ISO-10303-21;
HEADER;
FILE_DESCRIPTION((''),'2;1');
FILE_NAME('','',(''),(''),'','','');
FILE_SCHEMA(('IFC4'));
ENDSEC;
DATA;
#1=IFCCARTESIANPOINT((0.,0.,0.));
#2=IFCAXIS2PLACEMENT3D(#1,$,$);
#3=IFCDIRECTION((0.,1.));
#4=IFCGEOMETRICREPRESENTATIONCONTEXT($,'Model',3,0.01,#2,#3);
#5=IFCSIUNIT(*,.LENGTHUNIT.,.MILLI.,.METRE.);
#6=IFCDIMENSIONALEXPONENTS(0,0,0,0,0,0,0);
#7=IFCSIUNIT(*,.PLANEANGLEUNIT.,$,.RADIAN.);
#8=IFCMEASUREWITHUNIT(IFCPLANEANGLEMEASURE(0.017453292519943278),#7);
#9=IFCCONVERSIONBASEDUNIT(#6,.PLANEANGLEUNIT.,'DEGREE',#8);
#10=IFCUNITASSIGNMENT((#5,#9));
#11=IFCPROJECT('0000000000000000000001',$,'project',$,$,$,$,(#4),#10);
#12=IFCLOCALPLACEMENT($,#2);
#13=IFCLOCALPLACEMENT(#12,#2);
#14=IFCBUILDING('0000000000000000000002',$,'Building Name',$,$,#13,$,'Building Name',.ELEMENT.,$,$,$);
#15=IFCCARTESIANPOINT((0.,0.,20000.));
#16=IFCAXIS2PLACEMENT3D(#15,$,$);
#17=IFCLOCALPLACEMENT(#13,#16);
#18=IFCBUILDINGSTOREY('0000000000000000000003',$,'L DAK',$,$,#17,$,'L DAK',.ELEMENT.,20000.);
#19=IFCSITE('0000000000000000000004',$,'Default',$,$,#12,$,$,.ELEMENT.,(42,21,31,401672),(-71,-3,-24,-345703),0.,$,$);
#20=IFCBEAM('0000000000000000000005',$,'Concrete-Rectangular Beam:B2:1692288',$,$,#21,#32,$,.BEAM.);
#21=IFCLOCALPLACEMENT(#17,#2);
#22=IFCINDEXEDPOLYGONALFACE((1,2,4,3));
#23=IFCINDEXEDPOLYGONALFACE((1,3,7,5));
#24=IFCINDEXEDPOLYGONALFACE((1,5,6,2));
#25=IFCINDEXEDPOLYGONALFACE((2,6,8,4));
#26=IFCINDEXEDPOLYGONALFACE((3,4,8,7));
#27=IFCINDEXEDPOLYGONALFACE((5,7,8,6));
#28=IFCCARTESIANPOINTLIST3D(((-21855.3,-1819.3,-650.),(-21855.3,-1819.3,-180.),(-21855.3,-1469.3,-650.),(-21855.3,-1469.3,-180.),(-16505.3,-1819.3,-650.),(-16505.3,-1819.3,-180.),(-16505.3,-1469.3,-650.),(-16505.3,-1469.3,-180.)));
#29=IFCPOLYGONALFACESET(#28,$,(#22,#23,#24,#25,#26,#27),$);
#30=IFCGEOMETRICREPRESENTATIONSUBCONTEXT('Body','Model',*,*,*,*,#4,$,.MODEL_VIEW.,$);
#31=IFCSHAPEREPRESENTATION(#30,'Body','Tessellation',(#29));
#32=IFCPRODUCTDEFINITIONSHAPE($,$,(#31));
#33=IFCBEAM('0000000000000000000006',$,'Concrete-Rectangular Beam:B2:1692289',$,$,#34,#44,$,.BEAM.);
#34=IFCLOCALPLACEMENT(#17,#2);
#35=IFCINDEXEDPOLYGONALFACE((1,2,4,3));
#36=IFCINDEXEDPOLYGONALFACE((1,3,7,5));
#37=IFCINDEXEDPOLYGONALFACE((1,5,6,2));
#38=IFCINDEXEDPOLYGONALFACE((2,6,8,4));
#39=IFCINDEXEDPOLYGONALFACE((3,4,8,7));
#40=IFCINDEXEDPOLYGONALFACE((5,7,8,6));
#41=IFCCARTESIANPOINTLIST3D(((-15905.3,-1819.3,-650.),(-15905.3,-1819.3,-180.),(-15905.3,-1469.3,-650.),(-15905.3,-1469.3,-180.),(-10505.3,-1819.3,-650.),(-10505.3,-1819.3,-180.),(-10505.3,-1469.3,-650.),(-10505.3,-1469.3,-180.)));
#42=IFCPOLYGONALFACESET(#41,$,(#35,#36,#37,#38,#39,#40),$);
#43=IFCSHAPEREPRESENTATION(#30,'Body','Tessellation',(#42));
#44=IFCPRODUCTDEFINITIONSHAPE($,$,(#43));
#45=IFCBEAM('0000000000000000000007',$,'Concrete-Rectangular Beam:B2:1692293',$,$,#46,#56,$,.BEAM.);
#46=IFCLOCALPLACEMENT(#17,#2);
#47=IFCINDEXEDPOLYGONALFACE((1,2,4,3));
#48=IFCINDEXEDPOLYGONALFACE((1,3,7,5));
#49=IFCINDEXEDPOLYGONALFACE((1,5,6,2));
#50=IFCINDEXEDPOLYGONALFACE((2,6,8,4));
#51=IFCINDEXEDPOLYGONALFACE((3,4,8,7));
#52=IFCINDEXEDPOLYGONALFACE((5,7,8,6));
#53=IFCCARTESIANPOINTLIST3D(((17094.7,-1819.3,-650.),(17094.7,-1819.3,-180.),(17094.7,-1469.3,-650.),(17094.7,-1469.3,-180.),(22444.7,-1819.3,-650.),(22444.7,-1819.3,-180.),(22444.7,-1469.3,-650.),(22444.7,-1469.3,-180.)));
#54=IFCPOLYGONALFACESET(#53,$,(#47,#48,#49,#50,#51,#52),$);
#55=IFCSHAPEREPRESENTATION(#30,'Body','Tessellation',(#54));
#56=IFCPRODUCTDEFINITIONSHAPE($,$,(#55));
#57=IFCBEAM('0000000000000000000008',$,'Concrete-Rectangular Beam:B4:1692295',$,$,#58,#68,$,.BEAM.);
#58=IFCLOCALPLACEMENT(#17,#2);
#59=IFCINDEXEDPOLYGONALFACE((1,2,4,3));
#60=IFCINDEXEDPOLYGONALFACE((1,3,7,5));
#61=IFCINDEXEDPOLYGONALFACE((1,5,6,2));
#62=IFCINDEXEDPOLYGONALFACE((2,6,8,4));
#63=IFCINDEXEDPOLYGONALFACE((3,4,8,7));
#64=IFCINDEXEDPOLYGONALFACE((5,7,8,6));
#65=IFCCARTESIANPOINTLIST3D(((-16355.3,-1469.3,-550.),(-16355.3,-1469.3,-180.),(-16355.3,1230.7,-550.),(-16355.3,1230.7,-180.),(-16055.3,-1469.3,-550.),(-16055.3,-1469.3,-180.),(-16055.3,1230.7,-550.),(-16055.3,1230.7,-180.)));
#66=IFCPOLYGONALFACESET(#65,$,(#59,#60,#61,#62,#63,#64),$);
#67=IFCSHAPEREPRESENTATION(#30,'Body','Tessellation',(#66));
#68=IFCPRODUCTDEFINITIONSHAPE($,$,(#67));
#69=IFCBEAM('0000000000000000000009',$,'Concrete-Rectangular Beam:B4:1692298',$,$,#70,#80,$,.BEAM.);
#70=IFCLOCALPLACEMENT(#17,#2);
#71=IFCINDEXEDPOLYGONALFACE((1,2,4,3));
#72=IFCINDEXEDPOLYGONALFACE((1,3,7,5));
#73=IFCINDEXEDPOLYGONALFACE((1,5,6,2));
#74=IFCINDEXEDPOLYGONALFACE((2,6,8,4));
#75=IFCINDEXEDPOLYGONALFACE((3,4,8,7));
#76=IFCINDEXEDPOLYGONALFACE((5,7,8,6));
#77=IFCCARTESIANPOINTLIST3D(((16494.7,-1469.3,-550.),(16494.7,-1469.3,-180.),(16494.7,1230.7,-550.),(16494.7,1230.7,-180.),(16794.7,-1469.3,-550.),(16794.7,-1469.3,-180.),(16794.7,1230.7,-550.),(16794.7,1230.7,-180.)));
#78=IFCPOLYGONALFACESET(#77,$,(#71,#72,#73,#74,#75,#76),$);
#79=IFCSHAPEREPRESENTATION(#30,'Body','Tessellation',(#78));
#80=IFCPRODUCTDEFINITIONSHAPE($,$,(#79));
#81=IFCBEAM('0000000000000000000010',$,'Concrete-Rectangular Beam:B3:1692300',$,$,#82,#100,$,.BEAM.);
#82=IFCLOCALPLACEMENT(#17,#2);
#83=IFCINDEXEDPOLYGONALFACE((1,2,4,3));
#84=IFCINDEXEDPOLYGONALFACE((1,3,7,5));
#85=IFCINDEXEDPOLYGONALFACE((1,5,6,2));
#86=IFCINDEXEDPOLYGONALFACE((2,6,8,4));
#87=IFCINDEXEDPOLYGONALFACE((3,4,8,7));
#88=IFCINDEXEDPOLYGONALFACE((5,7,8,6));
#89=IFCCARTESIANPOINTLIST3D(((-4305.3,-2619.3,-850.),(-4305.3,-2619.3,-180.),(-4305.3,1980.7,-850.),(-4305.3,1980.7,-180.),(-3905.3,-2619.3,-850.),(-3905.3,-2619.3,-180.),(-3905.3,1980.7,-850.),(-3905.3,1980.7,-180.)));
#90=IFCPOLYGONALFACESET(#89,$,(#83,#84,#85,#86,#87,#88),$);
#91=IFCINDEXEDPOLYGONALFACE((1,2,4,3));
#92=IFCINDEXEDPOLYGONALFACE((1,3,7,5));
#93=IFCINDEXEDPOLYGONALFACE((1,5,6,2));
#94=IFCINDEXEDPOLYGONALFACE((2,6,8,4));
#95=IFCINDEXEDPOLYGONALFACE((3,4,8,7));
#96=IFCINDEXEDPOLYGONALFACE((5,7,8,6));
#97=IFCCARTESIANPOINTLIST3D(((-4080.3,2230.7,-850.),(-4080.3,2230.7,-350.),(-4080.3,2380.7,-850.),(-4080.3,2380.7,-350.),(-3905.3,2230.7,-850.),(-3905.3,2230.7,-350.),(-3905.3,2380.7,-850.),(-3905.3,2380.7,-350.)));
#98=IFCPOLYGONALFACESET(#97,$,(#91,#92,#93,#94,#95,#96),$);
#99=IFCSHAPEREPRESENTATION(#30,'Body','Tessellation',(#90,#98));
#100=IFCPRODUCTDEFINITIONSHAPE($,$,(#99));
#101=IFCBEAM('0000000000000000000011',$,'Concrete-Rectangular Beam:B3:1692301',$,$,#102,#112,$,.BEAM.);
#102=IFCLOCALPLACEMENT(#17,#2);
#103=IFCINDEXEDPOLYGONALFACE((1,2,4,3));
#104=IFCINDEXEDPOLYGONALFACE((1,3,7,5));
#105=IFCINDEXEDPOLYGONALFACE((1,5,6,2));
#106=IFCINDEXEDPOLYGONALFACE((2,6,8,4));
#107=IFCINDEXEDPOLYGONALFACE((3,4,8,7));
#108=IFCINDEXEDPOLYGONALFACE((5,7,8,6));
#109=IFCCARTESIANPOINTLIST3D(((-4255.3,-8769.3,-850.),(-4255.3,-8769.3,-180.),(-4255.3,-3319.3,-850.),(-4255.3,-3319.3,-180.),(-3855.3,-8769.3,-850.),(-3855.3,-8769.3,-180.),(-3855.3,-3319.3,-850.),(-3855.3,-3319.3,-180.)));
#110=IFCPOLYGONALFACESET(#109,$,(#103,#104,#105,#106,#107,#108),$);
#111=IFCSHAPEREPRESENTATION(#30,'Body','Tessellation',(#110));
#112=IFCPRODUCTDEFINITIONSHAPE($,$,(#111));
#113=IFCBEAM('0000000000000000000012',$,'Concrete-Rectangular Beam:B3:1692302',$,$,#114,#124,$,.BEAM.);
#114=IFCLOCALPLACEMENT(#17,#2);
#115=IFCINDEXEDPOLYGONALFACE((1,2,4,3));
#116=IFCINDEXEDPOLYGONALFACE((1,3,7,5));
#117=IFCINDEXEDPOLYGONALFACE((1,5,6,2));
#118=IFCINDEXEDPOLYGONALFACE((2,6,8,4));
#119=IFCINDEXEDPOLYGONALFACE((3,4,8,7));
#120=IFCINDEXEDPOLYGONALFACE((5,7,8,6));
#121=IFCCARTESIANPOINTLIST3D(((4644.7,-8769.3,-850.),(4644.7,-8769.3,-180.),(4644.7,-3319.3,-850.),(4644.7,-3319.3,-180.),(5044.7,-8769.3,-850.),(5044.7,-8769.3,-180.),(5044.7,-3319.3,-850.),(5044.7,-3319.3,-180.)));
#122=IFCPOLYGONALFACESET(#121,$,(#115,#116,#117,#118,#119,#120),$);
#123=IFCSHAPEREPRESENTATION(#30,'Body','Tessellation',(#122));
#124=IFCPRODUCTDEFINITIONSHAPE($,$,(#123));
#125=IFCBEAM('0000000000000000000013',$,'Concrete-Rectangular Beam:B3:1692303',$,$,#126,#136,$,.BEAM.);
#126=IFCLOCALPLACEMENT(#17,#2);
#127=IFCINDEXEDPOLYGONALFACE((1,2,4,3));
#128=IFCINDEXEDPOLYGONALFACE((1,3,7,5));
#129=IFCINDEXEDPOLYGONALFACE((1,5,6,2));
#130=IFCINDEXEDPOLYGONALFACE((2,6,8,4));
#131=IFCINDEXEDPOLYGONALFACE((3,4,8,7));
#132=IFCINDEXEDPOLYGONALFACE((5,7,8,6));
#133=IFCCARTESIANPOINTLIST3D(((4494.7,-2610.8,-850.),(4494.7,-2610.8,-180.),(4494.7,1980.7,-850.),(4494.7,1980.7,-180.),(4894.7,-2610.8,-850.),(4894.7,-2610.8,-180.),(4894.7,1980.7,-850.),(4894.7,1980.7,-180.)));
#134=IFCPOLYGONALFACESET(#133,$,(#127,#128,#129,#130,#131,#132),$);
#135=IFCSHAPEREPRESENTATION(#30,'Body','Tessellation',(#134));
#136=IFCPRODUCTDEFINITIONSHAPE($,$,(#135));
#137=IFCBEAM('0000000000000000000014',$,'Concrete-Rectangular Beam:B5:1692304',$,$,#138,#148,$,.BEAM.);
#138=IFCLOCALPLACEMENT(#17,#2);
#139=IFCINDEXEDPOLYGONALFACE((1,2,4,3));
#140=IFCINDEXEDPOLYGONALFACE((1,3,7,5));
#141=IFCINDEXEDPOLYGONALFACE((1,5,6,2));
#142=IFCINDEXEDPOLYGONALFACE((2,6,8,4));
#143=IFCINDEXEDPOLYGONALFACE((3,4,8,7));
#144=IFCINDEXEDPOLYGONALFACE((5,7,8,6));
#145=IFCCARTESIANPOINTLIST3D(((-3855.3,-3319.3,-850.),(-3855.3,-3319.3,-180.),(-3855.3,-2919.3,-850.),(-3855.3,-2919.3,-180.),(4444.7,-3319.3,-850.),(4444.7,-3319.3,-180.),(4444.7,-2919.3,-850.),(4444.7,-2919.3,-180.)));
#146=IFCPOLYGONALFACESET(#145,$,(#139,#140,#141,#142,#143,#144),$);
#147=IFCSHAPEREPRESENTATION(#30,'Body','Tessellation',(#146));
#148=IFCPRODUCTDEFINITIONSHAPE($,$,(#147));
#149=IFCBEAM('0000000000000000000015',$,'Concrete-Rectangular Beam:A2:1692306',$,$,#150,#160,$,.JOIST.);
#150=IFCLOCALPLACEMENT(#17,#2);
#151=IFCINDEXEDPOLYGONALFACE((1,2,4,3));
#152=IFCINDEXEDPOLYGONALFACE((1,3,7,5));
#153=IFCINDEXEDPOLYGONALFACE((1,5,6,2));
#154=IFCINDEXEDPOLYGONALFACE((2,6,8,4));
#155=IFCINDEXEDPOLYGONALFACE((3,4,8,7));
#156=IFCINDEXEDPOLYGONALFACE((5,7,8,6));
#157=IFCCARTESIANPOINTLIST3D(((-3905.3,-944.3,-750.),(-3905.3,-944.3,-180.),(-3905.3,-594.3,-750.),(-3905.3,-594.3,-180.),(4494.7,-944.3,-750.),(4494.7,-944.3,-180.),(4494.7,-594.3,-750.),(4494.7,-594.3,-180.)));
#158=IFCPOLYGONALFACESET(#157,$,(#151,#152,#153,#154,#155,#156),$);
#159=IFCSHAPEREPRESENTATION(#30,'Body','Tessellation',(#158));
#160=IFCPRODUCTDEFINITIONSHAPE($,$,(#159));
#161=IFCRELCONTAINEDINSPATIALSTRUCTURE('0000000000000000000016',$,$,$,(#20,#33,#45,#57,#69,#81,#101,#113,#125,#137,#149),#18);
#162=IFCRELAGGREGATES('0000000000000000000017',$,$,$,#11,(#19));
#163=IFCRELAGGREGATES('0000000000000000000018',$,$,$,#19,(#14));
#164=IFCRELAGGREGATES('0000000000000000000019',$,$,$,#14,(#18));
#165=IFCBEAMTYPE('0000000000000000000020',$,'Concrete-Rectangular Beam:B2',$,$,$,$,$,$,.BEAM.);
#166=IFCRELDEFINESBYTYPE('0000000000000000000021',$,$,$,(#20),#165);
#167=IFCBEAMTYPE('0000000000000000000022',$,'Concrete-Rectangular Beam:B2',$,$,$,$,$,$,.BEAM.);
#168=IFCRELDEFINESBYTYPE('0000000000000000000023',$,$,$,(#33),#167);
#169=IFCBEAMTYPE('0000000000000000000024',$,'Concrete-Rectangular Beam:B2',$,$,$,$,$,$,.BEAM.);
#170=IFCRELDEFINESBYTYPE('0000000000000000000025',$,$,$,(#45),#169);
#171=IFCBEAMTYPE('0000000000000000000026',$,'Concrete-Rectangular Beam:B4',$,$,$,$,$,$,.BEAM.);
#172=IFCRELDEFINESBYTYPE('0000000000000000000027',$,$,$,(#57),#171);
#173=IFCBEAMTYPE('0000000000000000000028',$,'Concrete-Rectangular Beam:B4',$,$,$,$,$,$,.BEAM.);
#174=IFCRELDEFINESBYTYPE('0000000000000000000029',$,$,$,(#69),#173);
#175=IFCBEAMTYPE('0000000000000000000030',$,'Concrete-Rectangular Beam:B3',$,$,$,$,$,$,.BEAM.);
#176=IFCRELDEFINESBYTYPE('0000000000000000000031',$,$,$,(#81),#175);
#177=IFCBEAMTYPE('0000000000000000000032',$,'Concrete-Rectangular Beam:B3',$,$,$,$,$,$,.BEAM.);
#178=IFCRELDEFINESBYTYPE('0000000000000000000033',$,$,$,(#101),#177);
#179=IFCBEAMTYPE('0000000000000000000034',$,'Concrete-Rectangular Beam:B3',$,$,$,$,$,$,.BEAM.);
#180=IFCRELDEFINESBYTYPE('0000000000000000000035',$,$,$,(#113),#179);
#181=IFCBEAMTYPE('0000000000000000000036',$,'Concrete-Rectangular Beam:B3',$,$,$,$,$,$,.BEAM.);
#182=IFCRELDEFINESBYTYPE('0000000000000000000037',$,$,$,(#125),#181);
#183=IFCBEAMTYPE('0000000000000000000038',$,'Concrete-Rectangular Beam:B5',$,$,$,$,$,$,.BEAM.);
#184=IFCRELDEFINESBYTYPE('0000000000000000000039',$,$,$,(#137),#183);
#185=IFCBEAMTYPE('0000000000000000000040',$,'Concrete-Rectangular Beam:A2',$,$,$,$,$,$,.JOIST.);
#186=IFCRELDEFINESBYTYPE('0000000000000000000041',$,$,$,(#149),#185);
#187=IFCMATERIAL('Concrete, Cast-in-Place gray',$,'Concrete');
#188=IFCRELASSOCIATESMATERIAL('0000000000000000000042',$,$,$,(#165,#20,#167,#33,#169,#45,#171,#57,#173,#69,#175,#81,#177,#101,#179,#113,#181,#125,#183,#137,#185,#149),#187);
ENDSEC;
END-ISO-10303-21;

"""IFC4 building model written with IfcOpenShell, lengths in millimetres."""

from ifc_helpers import new_model, entity, si_unit, converted_unit, direction, frame, origin, place, context, subcontext, project, spatial, indexed_curve, outline, extrude, source, transform, mapped, material, type_object, type_shapes, element, save


model = new_model("IFC4")

# Units and contexts
model_context = context("Model", 3, precision=0.01, world=origin(), true_north=direction((0.0, 1.0)))
body_context = subcontext(model_context, "Body", "Model", "MODEL_VIEW")
ifc_project = project(units=[si_unit("LENGTHUNIT", "METRE", prefix="MILLI"), converted_unit("PLANEANGLEUNIT", "DEGREE", entity("IfcPlaneAngleMeasure", 0.017453292519943278), si_unit("PLANEANGLEUNIT", "RADIAN"), dimensions=[0, 0, 0, 0, 0, 0, 0])], contexts=[model_context])

# Site, building, storey
site_placement = place(None, origin())
site = spatial("IfcSite", under=ifc_project, at=site_placement, Name="Default", CompositionType="ELEMENT", RefLatitude=(42, 21, 31, 401672), RefLongitude=(-71, -3, -24, -345703), RefElevation=0.0)
building_placement = place(site_placement, origin())
building = spatial("IfcBuilding", under=site, at=building_placement, Name="Building Name", LongName="Building Name", CompositionType="ELEMENT")
storey_placement = place(building_placement, frame((0.0, 0.0, 20000.0)))
storey = spatial("IfcBuildingStorey", under=building, at=storey_placement, Name="L DAK", LongName="L DAK", CompositionType="ELEMENT", Elevation=20000.0)

# Beams
ifc_material = material(Name="Concrete, Cast-in-Place gray", Category="Concrete")
beam_type_1 = type_object("IfcBeamType", Name="Concrete-Rectangular Beam:B2", PredefinedType="BEAM", material=ifc_material)
shared_shape_1 = source(origin(), body_context, "Body", "SweptSolid", [
    extrude(outline(indexed_curve([(-235.0, -175.0), (235.0, -175.0), (235.0, 175.0), (-235.0, 175.0), (-235.0, -175.0)], self_intersect=False)), frame((-21855.3, -1644.3, 19585.0), z_axis=(1.0, 0.0, 0.0), x_axis=(0.0, 0.0, -1.0)), (0.0, 0.0, 1.0), 5350.0),
])
type_shapes(beam_type_1, [shared_shape_1])
beam_1_placement = place(storey_placement, frame((0.0, 0.0, -20000.0)))
element("IfcBeam", 1, at=beam_1_placement, inside=storey, type_object=beam_type_1, material=ifc_material, Name="Concrete-Rectangular Beam:B2:1692288", PredefinedType="BEAM", context=body_context, shape_type="MappedRepresentation", body=[
    mapped(shared_shape_1, transform((0.0, 0.0, 0.0), scale=1.0)),
])
beam_type_2 = type_object("IfcBeamType", Name="Concrete-Rectangular Beam:B2", PredefinedType="BEAM", material=ifc_material)
shared_shape_2 = source(origin(), body_context, "Body", "SweptSolid", [
    extrude(outline(indexed_curve([(-235.0, -175.0), (235.0, -175.0), (235.0, 175.0), (-235.0, 175.0), (-235.0, -175.0)], self_intersect=False)), frame((-15905.3, -1644.3, 19585.0), z_axis=(1.0, 0.0, 0.0), x_axis=(0.0, 0.0, -1.0)), (0.0, 0.0, 1.0), 5400.0),
])
type_shapes(beam_type_2, [shared_shape_2])
beam_2_placement = place(storey_placement, frame((0.0, 0.0, -20000.0)))
element("IfcBeam", 2, at=beam_2_placement, inside=storey, type_object=beam_type_2, material=ifc_material, Name="Concrete-Rectangular Beam:B2:1692289", PredefinedType="BEAM", context=body_context, shape_type="MappedRepresentation", body=[
    mapped(shared_shape_2, transform((0.0, 0.0, 0.0), scale=1.0)),
])
beam_type_3 = type_object("IfcBeamType", Name="Concrete-Rectangular Beam:B2", PredefinedType="BEAM", material=ifc_material)
shared_shape_3 = source(origin(), body_context, "Body", "SweptSolid", [
    extrude(outline(indexed_curve([(-235.0, -175.0), (235.0, -175.0), (235.0, 175.0), (-235.0, 175.0), (-235.0, -175.0)], self_intersect=False)), frame((17094.7, -1644.3, 19585.0), z_axis=(1.0, 0.0, 0.0), x_axis=(0.0, 0.0, -1.0)), (0.0, 0.0, 1.0), 5350.0),
])
type_shapes(beam_type_3, [shared_shape_3])
beam_3_placement = place(storey_placement, frame((0.0, 0.0, -20000.0)))
element("IfcBeam", 3, at=beam_3_placement, inside=storey, type_object=beam_type_3, material=ifc_material, Name="Concrete-Rectangular Beam:B2:1692293", PredefinedType="BEAM", context=body_context, shape_type="MappedRepresentation", body=[
    mapped(shared_shape_3, transform((0.0, 0.0, 0.0), scale=1.0)),
])
beam_type_4 = type_object("IfcBeamType", Name="Concrete-Rectangular Beam:B4", PredefinedType="BEAM", material=ifc_material)
shared_shape_4 = source(origin(), body_context, "Body", "SweptSolid", [
    extrude(outline(indexed_curve([(-150.0, -185.0), (150.0, -185.0), (150.0, 185.0), (-150.0, 185.0), (-150.0, -185.0)], self_intersect=False)), frame((-16205.3, 1230.7, 19635.0), z_axis=(0.0, -1.0, 0.0), x_axis=(-1.0, 0.0, 0.0)), (0.0, 0.0, 1.0), 2700.0),
])
type_shapes(beam_type_4, [shared_shape_4])
beam_4_placement = place(storey_placement, frame((0.0, 0.0, -20000.0)))
element("IfcBeam", 4, at=beam_4_placement, inside=storey, type_object=beam_type_4, material=ifc_material, Name="Concrete-Rectangular Beam:B4:1692295", PredefinedType="BEAM", context=body_context, shape_type="MappedRepresentation", body=[
    mapped(shared_shape_4, transform((0.0, 0.0, 0.0), scale=1.0)),
])
beam_type_5 = type_object("IfcBeamType", Name="Concrete-Rectangular Beam:B4", PredefinedType="BEAM", material=ifc_material)
shared_shape_5 = source(origin(), body_context, "Body", "SweptSolid", [
    extrude(outline(indexed_curve([(-150.0, -185.0), (150.0, -185.0), (150.0, 185.0), (-150.0, 185.0), (-150.0, -185.0)], self_intersect=False)), frame((16644.7, 1230.7, 19635.0), z_axis=(0.0, -1.0, 0.0), x_axis=(-1.0, 0.0, 0.0)), (0.0, 0.0, 1.0), 2700.0),
])
type_shapes(beam_type_5, [shared_shape_5])
beam_5_placement = place(storey_placement, frame((0.0, 0.0, -20000.0)))
element("IfcBeam", 5, at=beam_5_placement, inside=storey, type_object=beam_type_5, material=ifc_material, Name="Concrete-Rectangular Beam:B4:1692298", PredefinedType="BEAM", context=body_context, shape_type="MappedRepresentation", body=[
    mapped(shared_shape_5, transform((0.0, 0.0, 0.0), scale=1.0)),
])
beam_type_6 = type_object("IfcBeamType", Name="Concrete-Rectangular Beam:B3", PredefinedType="BEAM", material=ifc_material)
shared_shape_6 = source(origin(), body_context, "Body", "SweptSolid", [
    extrude(outline(indexed_curve([(-200.0, -335.0), (200.0, -335.0), (200.0, 335.0), (-200.0, 335.0), (-200.0, -335.0)], self_intersect=False)), frame((-4105.3, 1980.7, 19485.0), z_axis=(0.0, -1.0, 0.0), x_axis=(-1.0, 0.0, 0.0)), (0.0, 0.0, 1.0), 4600.0),
    extrude(outline(indexed_curve([(-87.5, -250.0), (87.5, -250.0), (87.5, 250.0), (-87.5, 250.0), (-87.5, -250.0)], self_intersect=False)), frame((-3992.8, 2380.7, 19400.0), z_axis=(0.0, -1.0, 0.0), x_axis=(-1.0, 0.0, 0.0)), (0.0, 0.0, 1.0), 150.0),
])
type_shapes(beam_type_6, [shared_shape_6])
beam_6_placement = place(storey_placement, frame((0.0, 0.0, -20000.0)))
element("IfcBeam", 6, at=beam_6_placement, inside=storey, type_object=beam_type_6, material=ifc_material, Name="Concrete-Rectangular Beam:B3:1692300", PredefinedType="BEAM", context=body_context, shape_type="MappedRepresentation", body=[
    mapped(shared_shape_6, transform((0.0, 0.0, 0.0), scale=1.0)),
])
beam_type_7 = type_object("IfcBeamType", Name="Concrete-Rectangular Beam:B3", PredefinedType="BEAM", material=ifc_material)
shared_shape_7 = source(origin(), body_context, "Body", "SweptSolid", [
    extrude(outline(indexed_curve([(-200.0, -335.0), (200.0, -335.0), (200.0, 335.0), (-200.0, 335.0), (-200.0, -335.0)], self_intersect=False)), frame((-4055.3, -3319.3, 19485.0), z_axis=(0.0, -1.0, 0.0), x_axis=(-1.0, 0.0, 0.0)), (0.0, 0.0, 1.0), 5450.0),
])
type_shapes(beam_type_7, [shared_shape_7])
beam_7_placement = place(storey_placement, frame((0.0, 0.0, -20000.0)))
element("IfcBeam", 7, at=beam_7_placement, inside=storey, type_object=beam_type_7, material=ifc_material, Name="Concrete-Rectangular Beam:B3:1692301", PredefinedType="BEAM", context=body_context, shape_type="MappedRepresentation", body=[
    mapped(shared_shape_7, transform((0.0, 0.0, 0.0), scale=1.0)),
])
beam_type_8 = type_object("IfcBeamType", Name="Concrete-Rectangular Beam:B3", PredefinedType="BEAM", material=ifc_material)
shared_shape_8 = source(origin(), body_context, "Body", "SweptSolid", [
    extrude(outline(indexed_curve([(-200.0, -335.0), (200.0, -335.0), (200.0, 335.0), (-200.0, 335.0), (-200.0, -335.0)], self_intersect=False)), frame((4844.7, -8769.3, 19485.0), z_axis=(0.0, 1.0, 0.0), x_axis=(-1.0, 0.0, 0.0)), (0.0, 0.0, 1.0), 5450.0),
])
type_shapes(beam_type_8, [shared_shape_8])
beam_8_placement = place(storey_placement, frame((0.0, 0.0, -20000.0)))
element("IfcBeam", 8, at=beam_8_placement, inside=storey, type_object=beam_type_8, material=ifc_material, Name="Concrete-Rectangular Beam:B3:1692302", PredefinedType="BEAM", context=body_context, shape_type="MappedRepresentation", body=[
    mapped(shared_shape_8, transform((0.0, 0.0, 0.0), scale=1.0)),
])
beam_type_9 = type_object("IfcBeamType", Name="Concrete-Rectangular Beam:B3", PredefinedType="BEAM", material=ifc_material)
shared_shape_9 = source(origin(), body_context, "Body", "SweptSolid", [
    extrude(outline(indexed_curve([(-200.0, -335.0), (200.0, -335.0), (200.0, 335.0), (-200.0, 335.0), (-200.0, -335.0)], self_intersect=False)), frame((4694.7, -2610.8, 19485.0), z_axis=(0.0, 1.0, 0.0), x_axis=(-1.0, 0.0, 0.0)), (0.0, 0.0, 1.0), 4591.4),
])
type_shapes(beam_type_9, [shared_shape_9])
beam_9_placement = place(storey_placement, frame((0.0, 0.0, -20000.0)))
element("IfcBeam", 9, at=beam_9_placement, inside=storey, type_object=beam_type_9, material=ifc_material, Name="Concrete-Rectangular Beam:B3:1692303", PredefinedType="BEAM", context=body_context, shape_type="MappedRepresentation", body=[
    mapped(shared_shape_9, transform((0.0, 0.0, 0.0), scale=1.0)),
])
beam_type_10 = type_object("IfcBeamType", Name="Concrete-Rectangular Beam:B5", PredefinedType="BEAM", material=ifc_material)
shared_shape_10 = source(origin(), body_context, "Body", "SweptSolid", [
    extrude(outline(indexed_curve([(-335.0, -200.0), (335.0, -200.0), (335.0, 200.0), (-335.0, 200.0), (-335.0, -200.0)], self_intersect=False)), frame((-3855.3, -3119.3, 19485.0), z_axis=(1.0, 0.0, 0.0), x_axis=(0.0, 0.0, -1.0)), (0.0, 0.0, 1.0), 8300.0),
])
type_shapes(beam_type_10, [shared_shape_10])
beam_10_placement = place(storey_placement, frame((0.0, 0.0, -20000.0)))
element("IfcBeam", 10, at=beam_10_placement, inside=storey, type_object=beam_type_10, material=ifc_material, Name="Concrete-Rectangular Beam:B5:1692304", PredefinedType="BEAM", context=body_context, shape_type="MappedRepresentation", body=[
    mapped(shared_shape_10, transform((0.0, 0.0, 0.0), scale=1.0)),
])
beam_type_11 = type_object("IfcBeamType", Name="Concrete-Rectangular Beam:A2", PredefinedType="JOIST", material=ifc_material)
shared_shape_11 = source(origin(), body_context, "Body", "SweptSolid", [
    extrude(outline(indexed_curve([(-285.0, -175.0), (285.0, -175.0), (285.0, 175.0), (-285.0, 175.0), (-285.0, -175.0)], self_intersect=False)), frame((-3905.3, -769.3, 19535.0), z_axis=(1.0, 0.0, 0.0), x_axis=(0.0, 0.0, -1.0)), (0.0, 0.0, 1.0), 8400.0),
])
type_shapes(beam_type_11, [shared_shape_11])
beam_11_placement = place(storey_placement, frame((0.0, 0.0, -20000.0)))
element("IfcBeam", 11, at=beam_11_placement, inside=storey, type_object=beam_type_11, material=ifc_material, Name="Concrete-Rectangular Beam:A2:1692306", PredefinedType="JOIST", context=body_context, shape_type="MappedRepresentation", body=[
    mapped(shared_shape_11, transform((0.0, 0.0, 0.0), scale=1.0)),
])

save(model, "model.ifc")
